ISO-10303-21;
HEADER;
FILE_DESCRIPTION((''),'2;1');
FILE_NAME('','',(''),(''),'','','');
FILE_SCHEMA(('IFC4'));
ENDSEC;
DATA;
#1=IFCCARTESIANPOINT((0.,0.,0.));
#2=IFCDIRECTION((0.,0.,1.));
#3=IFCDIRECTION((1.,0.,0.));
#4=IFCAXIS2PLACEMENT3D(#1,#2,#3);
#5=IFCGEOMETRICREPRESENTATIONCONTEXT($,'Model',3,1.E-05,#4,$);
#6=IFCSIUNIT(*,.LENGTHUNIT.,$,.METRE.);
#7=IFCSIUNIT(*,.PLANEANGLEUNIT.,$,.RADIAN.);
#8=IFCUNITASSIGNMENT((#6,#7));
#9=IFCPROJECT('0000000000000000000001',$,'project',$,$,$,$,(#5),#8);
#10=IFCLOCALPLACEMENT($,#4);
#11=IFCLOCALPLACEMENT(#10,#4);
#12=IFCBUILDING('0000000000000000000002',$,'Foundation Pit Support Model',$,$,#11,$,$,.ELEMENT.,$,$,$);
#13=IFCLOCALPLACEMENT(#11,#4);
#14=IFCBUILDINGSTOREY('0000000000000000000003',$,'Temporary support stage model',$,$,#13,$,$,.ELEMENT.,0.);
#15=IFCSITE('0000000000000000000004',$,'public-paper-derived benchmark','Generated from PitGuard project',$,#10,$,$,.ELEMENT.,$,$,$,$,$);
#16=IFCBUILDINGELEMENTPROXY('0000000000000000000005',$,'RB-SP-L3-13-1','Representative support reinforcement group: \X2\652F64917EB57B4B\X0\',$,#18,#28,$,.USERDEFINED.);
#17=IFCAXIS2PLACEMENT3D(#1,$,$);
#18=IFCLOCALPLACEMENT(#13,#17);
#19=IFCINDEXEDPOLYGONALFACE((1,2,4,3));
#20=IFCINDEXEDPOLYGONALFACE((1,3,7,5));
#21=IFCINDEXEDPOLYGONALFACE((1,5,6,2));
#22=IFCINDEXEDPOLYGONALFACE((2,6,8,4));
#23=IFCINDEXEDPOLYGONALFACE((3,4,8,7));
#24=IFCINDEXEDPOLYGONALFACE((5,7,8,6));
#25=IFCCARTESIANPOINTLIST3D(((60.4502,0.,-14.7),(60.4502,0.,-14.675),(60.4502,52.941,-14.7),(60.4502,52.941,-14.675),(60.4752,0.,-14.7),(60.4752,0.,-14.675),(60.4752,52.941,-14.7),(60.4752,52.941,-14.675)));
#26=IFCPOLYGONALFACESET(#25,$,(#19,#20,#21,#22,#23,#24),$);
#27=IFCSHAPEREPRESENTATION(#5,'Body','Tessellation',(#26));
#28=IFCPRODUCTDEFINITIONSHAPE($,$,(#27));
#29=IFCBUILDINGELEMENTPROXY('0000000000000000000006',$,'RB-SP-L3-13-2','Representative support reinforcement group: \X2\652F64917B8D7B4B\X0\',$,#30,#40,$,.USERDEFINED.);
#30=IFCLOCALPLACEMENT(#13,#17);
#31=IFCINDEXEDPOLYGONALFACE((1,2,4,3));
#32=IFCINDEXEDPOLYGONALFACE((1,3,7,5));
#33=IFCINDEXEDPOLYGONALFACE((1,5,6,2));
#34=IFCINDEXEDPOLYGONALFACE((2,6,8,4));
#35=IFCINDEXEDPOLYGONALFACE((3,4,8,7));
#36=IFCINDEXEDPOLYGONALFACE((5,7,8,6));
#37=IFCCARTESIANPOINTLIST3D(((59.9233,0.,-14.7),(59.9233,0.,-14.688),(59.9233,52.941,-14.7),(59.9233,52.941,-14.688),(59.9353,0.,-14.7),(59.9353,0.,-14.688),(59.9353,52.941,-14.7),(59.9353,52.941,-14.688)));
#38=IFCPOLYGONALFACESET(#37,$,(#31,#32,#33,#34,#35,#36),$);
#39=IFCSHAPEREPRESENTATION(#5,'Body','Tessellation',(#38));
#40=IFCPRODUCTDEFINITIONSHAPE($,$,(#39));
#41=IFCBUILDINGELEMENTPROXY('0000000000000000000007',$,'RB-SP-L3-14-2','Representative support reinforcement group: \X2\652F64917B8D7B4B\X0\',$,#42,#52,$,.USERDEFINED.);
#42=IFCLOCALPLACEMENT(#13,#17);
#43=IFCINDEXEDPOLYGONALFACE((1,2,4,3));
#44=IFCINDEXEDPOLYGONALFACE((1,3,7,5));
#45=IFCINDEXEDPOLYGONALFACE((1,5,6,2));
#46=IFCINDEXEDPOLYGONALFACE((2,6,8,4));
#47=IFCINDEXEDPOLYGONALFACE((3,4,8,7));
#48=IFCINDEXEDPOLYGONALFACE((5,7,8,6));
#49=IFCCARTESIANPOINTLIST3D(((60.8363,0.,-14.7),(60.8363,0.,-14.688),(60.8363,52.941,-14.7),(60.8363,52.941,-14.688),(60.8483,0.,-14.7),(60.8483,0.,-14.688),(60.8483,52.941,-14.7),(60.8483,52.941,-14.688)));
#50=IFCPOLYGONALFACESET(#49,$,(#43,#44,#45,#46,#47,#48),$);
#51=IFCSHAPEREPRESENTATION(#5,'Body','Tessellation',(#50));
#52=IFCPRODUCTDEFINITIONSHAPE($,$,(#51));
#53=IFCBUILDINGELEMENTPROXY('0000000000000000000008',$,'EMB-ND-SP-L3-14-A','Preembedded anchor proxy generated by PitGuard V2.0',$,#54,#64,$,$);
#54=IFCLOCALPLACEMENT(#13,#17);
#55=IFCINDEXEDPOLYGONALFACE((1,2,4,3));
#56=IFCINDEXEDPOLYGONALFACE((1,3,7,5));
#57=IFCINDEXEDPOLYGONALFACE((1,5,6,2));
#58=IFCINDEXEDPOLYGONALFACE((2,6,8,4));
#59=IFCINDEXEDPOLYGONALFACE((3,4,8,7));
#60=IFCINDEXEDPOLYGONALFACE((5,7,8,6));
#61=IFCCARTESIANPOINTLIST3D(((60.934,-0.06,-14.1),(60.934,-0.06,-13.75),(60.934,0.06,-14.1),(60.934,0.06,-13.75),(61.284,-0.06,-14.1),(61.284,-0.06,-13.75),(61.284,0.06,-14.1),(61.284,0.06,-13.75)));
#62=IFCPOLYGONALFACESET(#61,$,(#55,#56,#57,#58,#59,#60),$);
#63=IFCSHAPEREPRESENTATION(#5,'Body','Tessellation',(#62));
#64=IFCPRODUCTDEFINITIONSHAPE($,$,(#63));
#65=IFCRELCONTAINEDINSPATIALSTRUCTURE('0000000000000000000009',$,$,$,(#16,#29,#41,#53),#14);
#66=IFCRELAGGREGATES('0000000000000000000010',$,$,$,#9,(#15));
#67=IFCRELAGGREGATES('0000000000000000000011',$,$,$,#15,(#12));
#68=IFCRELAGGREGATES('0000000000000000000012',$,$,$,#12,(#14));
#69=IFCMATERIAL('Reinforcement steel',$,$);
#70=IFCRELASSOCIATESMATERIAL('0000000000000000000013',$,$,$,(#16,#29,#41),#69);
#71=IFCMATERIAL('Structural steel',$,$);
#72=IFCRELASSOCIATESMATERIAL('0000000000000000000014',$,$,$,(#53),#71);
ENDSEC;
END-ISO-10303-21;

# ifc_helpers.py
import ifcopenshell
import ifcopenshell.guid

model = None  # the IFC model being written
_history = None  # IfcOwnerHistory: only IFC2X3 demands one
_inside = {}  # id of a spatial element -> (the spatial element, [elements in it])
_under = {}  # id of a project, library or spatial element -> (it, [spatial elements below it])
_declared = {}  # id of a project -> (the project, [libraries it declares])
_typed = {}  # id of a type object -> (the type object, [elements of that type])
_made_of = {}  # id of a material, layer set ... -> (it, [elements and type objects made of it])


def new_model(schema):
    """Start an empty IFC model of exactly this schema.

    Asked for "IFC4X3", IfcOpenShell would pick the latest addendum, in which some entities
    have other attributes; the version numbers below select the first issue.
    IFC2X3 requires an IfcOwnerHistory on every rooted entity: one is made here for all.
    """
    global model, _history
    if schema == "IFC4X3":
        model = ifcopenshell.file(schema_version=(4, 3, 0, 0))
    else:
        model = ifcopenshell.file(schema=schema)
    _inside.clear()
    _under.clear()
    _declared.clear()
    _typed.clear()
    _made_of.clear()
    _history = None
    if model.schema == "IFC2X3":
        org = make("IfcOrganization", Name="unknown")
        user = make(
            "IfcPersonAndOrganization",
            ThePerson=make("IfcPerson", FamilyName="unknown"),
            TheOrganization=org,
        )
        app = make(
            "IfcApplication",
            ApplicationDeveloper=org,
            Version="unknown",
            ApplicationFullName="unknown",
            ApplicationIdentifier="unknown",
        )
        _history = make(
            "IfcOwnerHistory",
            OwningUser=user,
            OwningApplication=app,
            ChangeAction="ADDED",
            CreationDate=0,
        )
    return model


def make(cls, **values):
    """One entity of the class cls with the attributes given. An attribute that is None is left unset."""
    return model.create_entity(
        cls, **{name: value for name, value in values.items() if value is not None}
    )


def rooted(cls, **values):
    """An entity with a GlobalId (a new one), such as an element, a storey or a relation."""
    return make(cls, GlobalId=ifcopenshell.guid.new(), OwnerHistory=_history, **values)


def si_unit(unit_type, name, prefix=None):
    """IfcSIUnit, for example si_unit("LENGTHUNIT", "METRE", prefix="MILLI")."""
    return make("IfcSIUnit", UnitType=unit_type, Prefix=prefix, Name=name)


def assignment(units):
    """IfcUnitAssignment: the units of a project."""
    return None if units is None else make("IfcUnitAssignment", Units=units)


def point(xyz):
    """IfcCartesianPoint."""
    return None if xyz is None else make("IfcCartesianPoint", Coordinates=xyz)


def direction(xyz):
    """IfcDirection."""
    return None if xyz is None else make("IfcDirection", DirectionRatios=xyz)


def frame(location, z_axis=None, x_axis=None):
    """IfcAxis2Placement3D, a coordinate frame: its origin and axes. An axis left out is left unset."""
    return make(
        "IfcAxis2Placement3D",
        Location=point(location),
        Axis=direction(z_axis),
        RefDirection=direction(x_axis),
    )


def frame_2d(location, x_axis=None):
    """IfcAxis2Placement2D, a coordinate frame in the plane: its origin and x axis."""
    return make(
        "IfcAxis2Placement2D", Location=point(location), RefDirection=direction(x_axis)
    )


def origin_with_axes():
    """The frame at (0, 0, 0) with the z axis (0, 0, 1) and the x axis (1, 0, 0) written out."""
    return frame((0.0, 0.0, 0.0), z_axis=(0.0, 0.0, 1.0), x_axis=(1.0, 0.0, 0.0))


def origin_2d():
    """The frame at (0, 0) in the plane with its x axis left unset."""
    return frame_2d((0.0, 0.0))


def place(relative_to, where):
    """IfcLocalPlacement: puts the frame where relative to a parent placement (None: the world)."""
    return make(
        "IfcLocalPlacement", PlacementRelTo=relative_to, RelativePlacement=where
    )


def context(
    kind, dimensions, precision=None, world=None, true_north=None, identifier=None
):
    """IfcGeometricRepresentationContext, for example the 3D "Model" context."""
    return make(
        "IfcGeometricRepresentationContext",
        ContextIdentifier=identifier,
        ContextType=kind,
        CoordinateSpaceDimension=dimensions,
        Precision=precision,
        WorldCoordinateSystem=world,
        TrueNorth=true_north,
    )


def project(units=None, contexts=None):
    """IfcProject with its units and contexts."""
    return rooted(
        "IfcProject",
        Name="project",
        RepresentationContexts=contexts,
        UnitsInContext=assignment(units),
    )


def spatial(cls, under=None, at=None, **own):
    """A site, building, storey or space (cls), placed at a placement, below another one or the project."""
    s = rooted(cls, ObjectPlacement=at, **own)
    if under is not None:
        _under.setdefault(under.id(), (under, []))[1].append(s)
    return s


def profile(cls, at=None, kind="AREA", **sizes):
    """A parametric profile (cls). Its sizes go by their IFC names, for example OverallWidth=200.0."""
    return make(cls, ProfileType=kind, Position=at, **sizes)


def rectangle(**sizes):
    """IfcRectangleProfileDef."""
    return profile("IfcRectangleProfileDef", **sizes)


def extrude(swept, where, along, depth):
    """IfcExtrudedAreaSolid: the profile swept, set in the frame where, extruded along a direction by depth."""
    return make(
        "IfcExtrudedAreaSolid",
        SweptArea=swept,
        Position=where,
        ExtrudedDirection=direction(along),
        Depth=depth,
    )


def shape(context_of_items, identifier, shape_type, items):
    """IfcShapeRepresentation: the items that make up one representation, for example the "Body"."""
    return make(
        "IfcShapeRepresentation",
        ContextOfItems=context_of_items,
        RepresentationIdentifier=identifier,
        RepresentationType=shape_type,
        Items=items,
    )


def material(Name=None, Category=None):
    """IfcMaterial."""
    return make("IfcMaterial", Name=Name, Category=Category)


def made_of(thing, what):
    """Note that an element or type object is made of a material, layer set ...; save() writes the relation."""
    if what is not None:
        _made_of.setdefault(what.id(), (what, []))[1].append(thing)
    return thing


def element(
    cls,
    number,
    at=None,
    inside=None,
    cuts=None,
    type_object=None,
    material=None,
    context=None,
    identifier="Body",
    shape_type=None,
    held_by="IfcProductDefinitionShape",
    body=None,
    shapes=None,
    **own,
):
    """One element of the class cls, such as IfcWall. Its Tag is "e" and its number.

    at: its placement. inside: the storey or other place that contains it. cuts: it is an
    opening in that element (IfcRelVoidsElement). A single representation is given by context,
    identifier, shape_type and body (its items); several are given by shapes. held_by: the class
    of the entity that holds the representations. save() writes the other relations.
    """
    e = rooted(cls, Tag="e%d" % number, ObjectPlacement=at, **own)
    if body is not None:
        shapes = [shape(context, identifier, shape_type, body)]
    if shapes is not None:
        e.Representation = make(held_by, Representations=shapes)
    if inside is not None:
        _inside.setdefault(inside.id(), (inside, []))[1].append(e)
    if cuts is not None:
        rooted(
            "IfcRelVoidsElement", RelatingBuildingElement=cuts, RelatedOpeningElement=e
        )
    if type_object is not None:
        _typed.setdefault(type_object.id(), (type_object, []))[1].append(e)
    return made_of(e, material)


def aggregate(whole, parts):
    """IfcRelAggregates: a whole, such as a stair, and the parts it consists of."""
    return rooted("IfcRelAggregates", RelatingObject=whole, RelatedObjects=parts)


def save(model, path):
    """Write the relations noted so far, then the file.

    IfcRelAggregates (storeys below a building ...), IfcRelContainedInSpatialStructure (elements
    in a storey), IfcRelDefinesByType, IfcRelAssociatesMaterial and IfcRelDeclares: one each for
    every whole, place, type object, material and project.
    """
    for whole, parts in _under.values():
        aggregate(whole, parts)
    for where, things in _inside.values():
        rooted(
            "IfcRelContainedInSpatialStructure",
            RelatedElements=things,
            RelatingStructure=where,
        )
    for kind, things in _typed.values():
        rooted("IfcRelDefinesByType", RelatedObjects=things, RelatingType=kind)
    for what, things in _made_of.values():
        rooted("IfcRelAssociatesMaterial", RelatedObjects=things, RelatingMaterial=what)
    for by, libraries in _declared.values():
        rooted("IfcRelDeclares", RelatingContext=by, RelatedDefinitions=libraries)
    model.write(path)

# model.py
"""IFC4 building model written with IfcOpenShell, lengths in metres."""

from ifc_helpers import new_model, si_unit, frame, origin_with_axes, origin_2d, place, context, project, spatial, rectangle, extrude, material, element, save


model = new_model("IFC4")

# Units and contexts
model_context = context("Model", 3, precision=1e-05, world=origin_with_axes())
ifc_project = project(units=[si_unit("LENGTHUNIT", "METRE"), si_unit("PLANEANGLEUNIT", "RADIAN")], contexts=[model_context])

# Site, building, storey
site_placement = place(None, origin_with_axes())
site = spatial("IfcSite", under=ifc_project, at=site_placement, Name="public-paper-derived benchmark", Description="Generated from PitGuard project", CompositionType="ELEMENT")
building_placement = place(site_placement, origin_with_axes())
building = spatial("IfcBuilding", under=site, at=building_placement, Name="Foundation Pit Support Model", CompositionType="ELEMENT")
storey_placement = place(building_placement, origin_with_axes())
storey = spatial("IfcBuildingStorey", under=building, at=storey_placement, Name="Temporary support stage model", CompositionType="ELEMENT", Elevation=0.0)

# Shared definitions
ifc_material_1 = material(Name="Structural steel")

# Building element proxies
ifc_material_2 = material(Name="Reinforcement steel")
proxy_1_placement = place(storey_placement, frame((60.4627, 26.4705, -14.7), z_axis=(0.0, 0.0, 1.0), x_axis=(0.0, 1.0, 0.0)))
element("IfcBuildingElementProxy", 1, at=proxy_1_placement, inside=storey, material=ifc_material_2, Name="RB-SP-L3-13-1", Description="Representative support reinforcement group: 支撑纵筋", PredefinedType="USERDEFINED", context=model_context, shape_type="SweptSolid", body=[
    extrude(rectangle(XDim=52.941, YDim=0.025, at=origin_2d()), origin_with_axes(), (0.0, 0.0, 1.0), 0.025),
])
for number, where, z_axis, x_axis, name in (
    (2, (59.9293, 26.4705, -14.7), (0.0, 0.0, 1.0), (0.0, 1.0, 0.0), "RB-SP-L3-13-2"),
    (3, (60.8423, 26.4705, -14.7), (0.0, 0.0, 1.0), (0.0, 1.0, 0.0), "RB-SP-L3-14-2"),
):
    element("IfcBuildingElementProxy", number, at=place(storey_placement, frame(where, z_axis=z_axis, x_axis=x_axis)), inside=storey, material=ifc_material_2, Name=name, Description="Representative support reinforcement group: 支撑箍筋", PredefinedType="USERDEFINED", context=model_context, shape_type="SweptSolid", body=[
        extrude(rectangle(XDim=52.941, YDim=0.012, at=origin_2d()), origin_with_axes(), (0.0, 0.0, 1.0), 0.012),
    ])
proxy_2_placement = place(storey_placement, frame((61.109, 0.0, -14.1), z_axis=(0.0, 0.0, 1.0), x_axis=(1.0, 0.0, 0.0)))
element("IfcBuildingElementProxy", 4, at=proxy_2_placement, inside=storey, material=ifc_material_1, Name="EMB-ND-SP-L3-14-A", Description="Preembedded anchor proxy generated by PitGuard V2.0", context=model_context, shape_type="SweptSolid", body=[
    extrude(rectangle(XDim=0.35, YDim=0.12, at=origin_2d()), origin_with_axes(), (0.0, 0.0, 1.0), 0.35),
])

save(model, "model.ifc")
